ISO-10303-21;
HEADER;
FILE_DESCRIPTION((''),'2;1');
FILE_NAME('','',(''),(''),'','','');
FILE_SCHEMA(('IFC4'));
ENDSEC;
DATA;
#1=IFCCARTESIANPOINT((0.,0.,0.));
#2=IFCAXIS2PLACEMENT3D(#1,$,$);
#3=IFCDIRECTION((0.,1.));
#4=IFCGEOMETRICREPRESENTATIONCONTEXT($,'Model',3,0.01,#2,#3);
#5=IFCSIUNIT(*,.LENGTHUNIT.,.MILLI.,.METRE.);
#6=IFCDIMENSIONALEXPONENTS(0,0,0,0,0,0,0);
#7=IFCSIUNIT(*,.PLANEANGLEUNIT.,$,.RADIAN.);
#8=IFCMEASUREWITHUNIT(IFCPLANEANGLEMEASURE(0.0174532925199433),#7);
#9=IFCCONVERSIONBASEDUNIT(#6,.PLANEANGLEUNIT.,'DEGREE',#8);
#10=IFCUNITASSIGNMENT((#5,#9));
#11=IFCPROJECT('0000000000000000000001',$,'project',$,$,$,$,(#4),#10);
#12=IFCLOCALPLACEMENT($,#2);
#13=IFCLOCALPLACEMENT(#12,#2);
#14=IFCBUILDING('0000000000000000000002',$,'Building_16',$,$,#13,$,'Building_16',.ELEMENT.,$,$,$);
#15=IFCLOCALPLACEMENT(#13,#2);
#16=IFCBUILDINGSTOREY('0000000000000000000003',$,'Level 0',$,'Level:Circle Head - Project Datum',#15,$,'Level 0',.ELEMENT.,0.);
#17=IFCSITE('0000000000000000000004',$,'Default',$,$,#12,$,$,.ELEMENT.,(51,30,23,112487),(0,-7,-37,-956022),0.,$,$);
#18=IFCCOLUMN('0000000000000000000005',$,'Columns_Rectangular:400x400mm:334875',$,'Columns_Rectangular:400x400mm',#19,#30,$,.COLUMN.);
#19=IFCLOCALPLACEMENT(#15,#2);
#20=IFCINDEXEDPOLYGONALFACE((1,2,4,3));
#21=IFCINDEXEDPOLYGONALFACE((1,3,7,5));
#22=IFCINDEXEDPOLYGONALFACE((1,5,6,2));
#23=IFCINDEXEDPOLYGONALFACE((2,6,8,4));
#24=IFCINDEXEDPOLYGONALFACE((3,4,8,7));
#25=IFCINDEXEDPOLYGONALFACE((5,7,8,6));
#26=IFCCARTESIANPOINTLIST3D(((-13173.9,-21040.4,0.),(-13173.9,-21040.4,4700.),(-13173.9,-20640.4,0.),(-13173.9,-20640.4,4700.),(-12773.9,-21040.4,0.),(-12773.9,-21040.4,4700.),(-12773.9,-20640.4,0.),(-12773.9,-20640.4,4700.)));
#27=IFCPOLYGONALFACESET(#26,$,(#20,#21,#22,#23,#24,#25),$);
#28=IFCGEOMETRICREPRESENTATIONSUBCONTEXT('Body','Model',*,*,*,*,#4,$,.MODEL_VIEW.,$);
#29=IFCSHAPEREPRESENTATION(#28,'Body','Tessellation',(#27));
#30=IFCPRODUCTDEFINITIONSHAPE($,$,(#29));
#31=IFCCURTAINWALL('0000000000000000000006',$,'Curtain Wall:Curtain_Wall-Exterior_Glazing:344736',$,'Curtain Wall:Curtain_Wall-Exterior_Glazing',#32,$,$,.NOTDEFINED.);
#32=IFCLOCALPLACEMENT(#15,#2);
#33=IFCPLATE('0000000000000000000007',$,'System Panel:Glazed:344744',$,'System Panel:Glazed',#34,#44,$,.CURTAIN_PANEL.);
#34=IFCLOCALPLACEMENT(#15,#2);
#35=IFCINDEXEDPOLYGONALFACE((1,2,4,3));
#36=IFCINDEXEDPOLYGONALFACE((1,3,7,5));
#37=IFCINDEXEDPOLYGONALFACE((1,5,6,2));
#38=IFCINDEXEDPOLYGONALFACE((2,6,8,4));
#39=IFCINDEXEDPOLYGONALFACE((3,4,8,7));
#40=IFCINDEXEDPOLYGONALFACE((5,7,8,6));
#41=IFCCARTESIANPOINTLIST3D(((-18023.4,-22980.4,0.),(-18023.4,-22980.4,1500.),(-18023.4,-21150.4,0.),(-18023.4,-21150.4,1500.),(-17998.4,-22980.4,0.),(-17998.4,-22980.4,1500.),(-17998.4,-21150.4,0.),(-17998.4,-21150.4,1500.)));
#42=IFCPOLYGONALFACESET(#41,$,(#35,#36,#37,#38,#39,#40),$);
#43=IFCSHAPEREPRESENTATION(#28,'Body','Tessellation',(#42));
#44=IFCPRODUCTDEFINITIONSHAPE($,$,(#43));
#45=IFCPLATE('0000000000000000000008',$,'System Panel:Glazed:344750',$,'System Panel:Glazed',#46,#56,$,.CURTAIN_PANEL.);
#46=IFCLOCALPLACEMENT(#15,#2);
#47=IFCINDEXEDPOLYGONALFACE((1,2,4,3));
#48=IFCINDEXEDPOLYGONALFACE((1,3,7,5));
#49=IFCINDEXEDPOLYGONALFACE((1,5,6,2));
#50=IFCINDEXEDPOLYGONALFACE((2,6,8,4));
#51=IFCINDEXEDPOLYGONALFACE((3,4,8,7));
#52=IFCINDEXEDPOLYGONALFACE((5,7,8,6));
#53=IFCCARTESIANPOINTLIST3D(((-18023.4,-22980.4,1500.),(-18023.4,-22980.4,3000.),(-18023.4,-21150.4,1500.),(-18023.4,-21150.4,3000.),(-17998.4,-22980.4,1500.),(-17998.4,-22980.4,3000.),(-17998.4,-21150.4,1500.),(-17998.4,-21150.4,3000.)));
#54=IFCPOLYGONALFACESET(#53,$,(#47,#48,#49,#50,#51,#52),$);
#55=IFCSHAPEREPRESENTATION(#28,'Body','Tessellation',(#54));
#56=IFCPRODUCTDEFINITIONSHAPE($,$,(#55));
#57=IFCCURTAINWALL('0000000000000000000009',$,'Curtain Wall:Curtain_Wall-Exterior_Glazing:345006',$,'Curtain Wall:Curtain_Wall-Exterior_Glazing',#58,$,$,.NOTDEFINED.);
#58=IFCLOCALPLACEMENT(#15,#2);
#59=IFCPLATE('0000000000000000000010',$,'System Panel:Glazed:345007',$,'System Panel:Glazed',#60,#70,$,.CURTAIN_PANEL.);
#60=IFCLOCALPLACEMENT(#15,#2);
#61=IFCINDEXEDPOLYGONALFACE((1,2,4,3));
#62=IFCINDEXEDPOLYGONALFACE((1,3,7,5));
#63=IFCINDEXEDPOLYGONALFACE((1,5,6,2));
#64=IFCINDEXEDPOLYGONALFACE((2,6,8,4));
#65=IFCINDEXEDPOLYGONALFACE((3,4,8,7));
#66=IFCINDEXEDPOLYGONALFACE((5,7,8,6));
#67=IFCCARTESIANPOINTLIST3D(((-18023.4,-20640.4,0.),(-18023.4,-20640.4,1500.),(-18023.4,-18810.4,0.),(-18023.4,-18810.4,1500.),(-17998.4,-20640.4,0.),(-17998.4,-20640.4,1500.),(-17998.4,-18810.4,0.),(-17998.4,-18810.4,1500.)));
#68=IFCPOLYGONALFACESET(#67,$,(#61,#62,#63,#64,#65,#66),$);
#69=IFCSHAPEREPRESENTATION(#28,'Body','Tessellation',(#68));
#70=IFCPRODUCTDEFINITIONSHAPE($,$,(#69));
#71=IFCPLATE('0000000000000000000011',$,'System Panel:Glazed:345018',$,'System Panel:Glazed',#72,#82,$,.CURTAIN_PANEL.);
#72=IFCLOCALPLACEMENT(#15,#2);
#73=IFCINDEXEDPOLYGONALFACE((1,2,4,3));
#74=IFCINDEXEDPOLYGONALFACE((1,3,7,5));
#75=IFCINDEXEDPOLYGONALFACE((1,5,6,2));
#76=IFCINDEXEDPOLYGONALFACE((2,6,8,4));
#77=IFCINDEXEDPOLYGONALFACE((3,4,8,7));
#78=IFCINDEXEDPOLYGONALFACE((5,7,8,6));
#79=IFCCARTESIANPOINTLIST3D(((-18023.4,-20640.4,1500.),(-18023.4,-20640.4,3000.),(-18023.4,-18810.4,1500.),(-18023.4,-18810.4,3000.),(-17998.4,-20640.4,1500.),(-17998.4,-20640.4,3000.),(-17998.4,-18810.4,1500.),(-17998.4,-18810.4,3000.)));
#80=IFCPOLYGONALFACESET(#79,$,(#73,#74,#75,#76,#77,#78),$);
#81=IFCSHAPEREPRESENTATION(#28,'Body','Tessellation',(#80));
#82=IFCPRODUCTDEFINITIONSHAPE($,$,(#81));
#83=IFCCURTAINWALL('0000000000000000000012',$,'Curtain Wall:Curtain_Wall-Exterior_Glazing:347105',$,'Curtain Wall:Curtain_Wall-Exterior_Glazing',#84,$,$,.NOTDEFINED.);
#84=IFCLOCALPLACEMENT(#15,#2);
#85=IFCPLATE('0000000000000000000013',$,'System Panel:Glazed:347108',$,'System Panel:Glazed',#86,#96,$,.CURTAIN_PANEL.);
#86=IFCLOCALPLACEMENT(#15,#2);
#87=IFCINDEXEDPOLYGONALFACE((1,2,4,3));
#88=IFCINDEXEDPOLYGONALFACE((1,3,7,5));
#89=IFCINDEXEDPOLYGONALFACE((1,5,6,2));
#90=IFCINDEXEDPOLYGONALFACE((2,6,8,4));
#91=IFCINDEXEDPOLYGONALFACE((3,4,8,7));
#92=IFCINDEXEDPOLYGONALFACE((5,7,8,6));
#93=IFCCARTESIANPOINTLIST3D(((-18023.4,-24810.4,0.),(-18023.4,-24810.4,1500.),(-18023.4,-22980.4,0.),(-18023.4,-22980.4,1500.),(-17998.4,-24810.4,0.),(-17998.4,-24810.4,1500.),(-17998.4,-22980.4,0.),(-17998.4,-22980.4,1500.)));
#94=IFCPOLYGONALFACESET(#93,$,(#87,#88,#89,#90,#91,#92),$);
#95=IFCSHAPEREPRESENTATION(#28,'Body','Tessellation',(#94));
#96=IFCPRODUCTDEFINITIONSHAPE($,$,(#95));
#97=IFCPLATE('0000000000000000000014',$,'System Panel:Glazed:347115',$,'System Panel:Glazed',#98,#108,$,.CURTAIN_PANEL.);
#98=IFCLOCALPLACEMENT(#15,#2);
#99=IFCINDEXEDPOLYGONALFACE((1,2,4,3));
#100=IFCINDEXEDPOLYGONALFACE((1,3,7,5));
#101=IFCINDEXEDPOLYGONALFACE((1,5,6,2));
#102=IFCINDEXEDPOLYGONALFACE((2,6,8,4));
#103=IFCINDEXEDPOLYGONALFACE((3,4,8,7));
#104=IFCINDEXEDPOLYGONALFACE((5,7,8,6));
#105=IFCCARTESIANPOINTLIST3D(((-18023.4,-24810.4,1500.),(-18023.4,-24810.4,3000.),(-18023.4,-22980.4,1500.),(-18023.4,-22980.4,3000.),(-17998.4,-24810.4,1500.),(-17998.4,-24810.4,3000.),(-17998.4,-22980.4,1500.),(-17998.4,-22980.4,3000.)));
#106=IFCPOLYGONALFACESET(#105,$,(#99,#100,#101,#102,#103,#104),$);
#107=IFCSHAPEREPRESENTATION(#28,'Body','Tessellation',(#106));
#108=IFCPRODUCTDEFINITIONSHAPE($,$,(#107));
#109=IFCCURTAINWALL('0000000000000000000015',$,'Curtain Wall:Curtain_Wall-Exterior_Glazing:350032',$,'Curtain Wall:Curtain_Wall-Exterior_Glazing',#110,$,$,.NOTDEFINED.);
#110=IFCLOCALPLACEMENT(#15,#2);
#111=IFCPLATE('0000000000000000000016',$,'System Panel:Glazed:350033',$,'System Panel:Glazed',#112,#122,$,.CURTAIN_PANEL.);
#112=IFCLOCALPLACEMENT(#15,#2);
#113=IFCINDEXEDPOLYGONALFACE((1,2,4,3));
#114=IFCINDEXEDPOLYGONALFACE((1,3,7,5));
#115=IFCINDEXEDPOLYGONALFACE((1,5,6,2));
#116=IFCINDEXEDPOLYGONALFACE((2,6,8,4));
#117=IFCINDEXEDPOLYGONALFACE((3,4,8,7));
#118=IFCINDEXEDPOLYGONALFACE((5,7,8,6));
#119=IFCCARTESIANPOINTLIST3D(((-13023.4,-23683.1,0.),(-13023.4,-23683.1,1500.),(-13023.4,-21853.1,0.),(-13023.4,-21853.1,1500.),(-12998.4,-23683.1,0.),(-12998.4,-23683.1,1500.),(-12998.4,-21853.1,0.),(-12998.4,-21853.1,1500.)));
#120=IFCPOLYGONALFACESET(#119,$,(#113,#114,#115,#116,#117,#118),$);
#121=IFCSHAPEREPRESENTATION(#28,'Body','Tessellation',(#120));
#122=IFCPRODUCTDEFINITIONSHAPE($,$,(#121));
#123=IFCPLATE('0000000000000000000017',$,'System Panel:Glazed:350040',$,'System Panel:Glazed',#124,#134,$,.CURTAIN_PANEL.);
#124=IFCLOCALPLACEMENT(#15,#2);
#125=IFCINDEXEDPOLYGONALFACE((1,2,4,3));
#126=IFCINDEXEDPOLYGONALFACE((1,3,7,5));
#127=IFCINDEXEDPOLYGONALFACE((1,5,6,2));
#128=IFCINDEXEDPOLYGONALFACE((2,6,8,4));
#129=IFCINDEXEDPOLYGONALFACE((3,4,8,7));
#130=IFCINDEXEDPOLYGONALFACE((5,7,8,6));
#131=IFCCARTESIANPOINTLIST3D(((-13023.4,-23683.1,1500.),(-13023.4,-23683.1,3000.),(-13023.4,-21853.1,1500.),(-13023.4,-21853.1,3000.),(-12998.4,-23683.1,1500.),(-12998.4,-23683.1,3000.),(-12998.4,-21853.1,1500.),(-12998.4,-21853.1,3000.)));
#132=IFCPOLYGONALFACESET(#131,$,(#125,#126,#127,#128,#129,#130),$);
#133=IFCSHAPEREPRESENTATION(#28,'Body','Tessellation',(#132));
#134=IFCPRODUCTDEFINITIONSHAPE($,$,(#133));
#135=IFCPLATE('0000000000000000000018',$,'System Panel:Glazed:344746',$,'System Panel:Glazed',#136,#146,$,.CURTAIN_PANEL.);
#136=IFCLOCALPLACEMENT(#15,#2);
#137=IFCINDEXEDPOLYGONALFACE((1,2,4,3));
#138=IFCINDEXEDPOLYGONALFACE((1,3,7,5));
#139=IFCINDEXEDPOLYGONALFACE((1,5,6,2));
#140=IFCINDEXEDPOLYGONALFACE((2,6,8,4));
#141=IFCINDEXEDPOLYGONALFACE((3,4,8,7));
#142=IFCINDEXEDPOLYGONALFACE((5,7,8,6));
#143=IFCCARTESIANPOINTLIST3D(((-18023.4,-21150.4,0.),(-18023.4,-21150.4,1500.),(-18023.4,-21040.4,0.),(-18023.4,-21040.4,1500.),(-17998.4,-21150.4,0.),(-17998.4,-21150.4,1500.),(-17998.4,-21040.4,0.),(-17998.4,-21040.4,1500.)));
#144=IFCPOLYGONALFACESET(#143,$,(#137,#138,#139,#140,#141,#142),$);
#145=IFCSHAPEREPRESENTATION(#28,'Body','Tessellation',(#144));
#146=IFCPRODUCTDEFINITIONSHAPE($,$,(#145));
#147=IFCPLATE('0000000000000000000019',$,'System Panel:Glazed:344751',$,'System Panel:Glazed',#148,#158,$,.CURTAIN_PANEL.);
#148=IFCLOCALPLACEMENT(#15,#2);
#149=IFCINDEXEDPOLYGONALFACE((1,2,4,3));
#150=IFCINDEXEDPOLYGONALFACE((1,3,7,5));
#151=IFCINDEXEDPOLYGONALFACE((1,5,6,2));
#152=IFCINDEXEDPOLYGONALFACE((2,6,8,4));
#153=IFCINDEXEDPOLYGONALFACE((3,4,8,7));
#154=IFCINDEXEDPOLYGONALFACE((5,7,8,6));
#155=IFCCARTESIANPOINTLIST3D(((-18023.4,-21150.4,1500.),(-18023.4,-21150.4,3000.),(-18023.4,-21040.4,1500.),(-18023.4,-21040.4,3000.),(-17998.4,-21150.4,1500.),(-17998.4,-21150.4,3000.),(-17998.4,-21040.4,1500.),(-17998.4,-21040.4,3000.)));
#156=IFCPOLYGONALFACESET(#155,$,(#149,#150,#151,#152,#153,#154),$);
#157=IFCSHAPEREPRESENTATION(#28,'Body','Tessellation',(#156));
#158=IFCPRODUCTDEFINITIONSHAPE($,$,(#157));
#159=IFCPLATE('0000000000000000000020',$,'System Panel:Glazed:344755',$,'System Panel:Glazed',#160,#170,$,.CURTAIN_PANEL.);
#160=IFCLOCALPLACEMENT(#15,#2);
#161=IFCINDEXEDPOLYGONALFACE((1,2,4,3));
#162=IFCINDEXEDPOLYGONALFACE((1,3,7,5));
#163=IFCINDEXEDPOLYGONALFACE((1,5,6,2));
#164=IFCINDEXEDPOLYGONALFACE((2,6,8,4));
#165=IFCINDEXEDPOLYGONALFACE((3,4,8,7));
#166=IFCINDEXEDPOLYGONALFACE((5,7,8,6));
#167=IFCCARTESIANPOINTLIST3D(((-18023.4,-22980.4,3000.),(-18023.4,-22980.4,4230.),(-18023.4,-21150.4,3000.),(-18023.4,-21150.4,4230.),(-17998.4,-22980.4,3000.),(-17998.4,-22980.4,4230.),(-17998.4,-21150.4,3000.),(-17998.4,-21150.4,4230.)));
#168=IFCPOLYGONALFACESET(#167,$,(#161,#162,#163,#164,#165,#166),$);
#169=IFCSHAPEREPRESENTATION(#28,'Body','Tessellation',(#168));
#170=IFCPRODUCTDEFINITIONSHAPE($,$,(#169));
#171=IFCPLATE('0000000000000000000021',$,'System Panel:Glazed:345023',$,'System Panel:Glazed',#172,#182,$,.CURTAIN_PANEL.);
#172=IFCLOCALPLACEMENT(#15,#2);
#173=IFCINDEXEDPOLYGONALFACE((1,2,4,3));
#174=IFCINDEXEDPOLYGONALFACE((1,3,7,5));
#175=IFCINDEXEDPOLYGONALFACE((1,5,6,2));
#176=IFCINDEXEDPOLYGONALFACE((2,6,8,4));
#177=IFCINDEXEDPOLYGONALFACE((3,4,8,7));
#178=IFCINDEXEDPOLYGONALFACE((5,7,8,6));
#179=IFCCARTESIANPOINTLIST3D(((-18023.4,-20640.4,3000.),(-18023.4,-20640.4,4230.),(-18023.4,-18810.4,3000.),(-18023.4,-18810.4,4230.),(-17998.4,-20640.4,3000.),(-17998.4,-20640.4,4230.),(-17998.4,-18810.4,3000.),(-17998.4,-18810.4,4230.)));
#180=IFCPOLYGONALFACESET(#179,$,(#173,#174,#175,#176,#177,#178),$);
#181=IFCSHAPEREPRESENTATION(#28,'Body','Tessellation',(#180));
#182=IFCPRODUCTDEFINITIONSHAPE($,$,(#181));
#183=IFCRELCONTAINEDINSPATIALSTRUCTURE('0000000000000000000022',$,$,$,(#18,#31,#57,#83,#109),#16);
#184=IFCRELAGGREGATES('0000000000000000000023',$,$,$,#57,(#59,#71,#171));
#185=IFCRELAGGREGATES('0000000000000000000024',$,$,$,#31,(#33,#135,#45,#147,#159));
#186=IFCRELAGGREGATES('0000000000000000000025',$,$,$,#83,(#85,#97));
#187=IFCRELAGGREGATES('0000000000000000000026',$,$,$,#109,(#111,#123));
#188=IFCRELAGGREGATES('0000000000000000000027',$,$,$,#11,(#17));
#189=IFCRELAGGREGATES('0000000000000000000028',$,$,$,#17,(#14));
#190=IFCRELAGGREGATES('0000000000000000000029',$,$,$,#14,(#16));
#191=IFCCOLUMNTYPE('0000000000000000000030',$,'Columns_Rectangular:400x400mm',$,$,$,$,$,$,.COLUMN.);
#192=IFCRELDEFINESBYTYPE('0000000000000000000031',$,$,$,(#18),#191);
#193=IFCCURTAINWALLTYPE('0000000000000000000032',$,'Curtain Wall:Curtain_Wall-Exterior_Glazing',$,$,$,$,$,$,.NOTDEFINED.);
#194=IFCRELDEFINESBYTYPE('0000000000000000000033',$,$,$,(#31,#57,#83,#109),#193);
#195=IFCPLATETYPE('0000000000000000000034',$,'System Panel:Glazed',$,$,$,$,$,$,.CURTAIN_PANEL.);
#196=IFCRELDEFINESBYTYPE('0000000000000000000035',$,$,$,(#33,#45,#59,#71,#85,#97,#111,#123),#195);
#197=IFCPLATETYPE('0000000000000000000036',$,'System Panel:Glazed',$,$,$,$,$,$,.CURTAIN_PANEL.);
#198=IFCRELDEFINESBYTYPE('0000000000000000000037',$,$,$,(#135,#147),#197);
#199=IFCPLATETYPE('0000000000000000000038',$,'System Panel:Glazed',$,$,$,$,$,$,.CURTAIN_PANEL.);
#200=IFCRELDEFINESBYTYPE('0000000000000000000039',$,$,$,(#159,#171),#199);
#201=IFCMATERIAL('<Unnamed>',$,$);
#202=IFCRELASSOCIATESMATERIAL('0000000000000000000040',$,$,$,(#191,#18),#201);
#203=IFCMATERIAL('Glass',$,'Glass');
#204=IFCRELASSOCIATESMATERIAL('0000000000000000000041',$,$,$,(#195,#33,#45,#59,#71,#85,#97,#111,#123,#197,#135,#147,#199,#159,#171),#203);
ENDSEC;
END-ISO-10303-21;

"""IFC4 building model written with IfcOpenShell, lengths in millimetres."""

from ifc_helpers import new_model, entity, si_unit, converted_unit, direction, frame, origin, place, context, subcontext, project, spatial, indexed_curve, outline, extrude, source, transform, mapped, material, type_object, type_shapes, element, aggregate, save


model = new_model("IFC4")

# Units and contexts
model_context = context("Model", 3, precision=0.01, world=origin(), true_north=direction((0.0, 1.0)))
body_context = subcontext(model_context, "Body", "Model", "MODEL_VIEW")
ifc_project = project(units=[si_unit("LENGTHUNIT", "METRE", prefix="MILLI"), converted_unit("PLANEANGLEUNIT", "DEGREE", entity("IfcPlaneAngleMeasure", 0.0174532925199433), si_unit("PLANEANGLEUNIT", "RADIAN"), dimensions=[0, 0, 0, 0, 0, 0, 0])], contexts=[model_context])

# Site, building, storey
site_placement = place(None, origin())
site = spatial("IfcSite", under=ifc_project, at=site_placement, Name="Default", CompositionType="ELEMENT", RefLatitude=(51, 30, 23, 112487), RefLongitude=(0, -7, -37, -956022), RefElevation=0.0)
building_placement = place(site_placement, origin())
building = spatial("IfcBuilding", under=site, at=building_placement, Name="Building_16", LongName="Building_16", CompositionType="ELEMENT")
storey_placement = place(building_placement, origin())
storey = spatial("IfcBuildingStorey", under=building, at=storey_placement, Name="Level 0", ObjectType="Level:Circle Head - Project Datum", LongName="Level 0", CompositionType="ELEMENT", Elevation=0.0)

# Column
ifc_material_1 = material(Name="<Unnamed>")
column_type = type_object("IfcColumnType", Name="Columns_Rectangular:400x400mm", PredefinedType="COLUMN", material=ifc_material_1)
shared_shape_1 = source(origin(), body_context, "Body", "SweptSolid", [
    extrude(outline(indexed_curve([(-200.0, -200.0), (200.0, -200.0), (200.0, 200.0), (-200.0, 200.0), (-200.0, -200.0)], self_intersect=False)), frame((0.0, 0.0, 0.0), z_axis=(0.0, 0.0, 1.0), x_axis=(-1.0, 0.0, 0.0)), (0.0, 0.0, 1.0), 4700.0),
])
type_shapes(column_type, [shared_shape_1])
column_placement = place(storey_placement, frame((-12973.9, -20840.4, 0.0)))
element("IfcColumn", 1, at=column_placement, inside=storey, type_object=column_type, material=ifc_material_1, Name="Columns_Rectangular:400x400mm:334875", ObjectType="Columns_Rectangular:400x400mm", PredefinedType="COLUMN", context=body_context, shape_type="MappedRepresentation", body=[
    mapped(shared_shape_1, transform((0.0, 0.0, 0.0), scale=1.0)),
])

# Curtain walls, plates
curtain_wall_type = type_object("IfcCurtainWallType", Name="Curtain Wall:Curtain_Wall-Exterior_Glazing", PredefinedType="NOTDEFINED")
curtain_wall_1_placement = place(storey_placement, origin())
curtain_wall_1 = element("IfcCurtainWall", 2, at=curtain_wall_1_placement, inside=storey, type_object=curtain_wall_type, Name="Curtain Wall:Curtain_Wall-Exterior_Glazing:344736", ObjectType="Curtain Wall:Curtain_Wall-Exterior_Glazing", PredefinedType="NOTDEFINED")
ifc_material_2 = material(Name="Glass", Category="Glass")
plate_type_1 = type_object("IfcPlateType", Name="System Panel:Glazed", PredefinedType="CURTAIN_PANEL", material=ifc_material_2)
shared_shape_2 = source(origin(), body_context, "Body", "SweptSolid", [
    extrude(outline(indexed_curve([(-12.5, -915.0), (12.5, -915.0), (12.5, 915.0), (-12.5, 915.0), (-12.5, -915.0)], self_intersect=False)), frame((0.0, 37.0, 0.0), z_axis=(0.0, 0.0, 1.0), x_axis=(0.0, 1.0, 0.0)), (0.0, 0.0, 1.0), 1500.0),
])
type_shapes(plate_type_1, [shared_shape_2])
plate_1_placement = place(curtain_wall_1_placement, frame((-17973.9, -22065.4, 0.0), z_axis=(0.0, 0.0, 1.0), x_axis=(0.0, 1.0, 0.0)))
plate_1 = element("IfcPlate", 3, at=plate_1_placement, type_object=plate_type_1, material=ifc_material_2, Name="System Panel:Glazed:344744", ObjectType="System Panel:Glazed", PredefinedType="CURTAIN_PANEL", context=body_context, shape_type="MappedRepresentation", body=[
    mapped(shared_shape_2, transform((0.0, 0.0, 0.0), scale=1.0)),
])
plate_2_placement = place(curtain_wall_1_placement, frame((-17973.9, -22065.4, 1500.0), z_axis=(0.0, 0.0, 1.0), x_axis=(0.0, 1.0, 0.0)))
plate_2 = element("IfcPlate", 4, at=plate_2_placement, type_object=plate_type_1, material=ifc_material_2, Name="System Panel:Glazed:344750", ObjectType="System Panel:Glazed", PredefinedType="CURTAIN_PANEL", context=body_context, shape_type="MappedRepresentation", body=[
    mapped(shared_shape_2, transform((0.0, 0.0, 0.0), scale=1.0)),
])
curtain_wall_2_placement = place(storey_placement, origin())
curtain_wall_2 = element("IfcCurtainWall", 5, at=curtain_wall_2_placement, inside=storey, type_object=curtain_wall_type, Name="Curtain Wall:Curtain_Wall-Exterior_Glazing:345006", ObjectType="Curtain Wall:Curtain_Wall-Exterior_Glazing", PredefinedType="NOTDEFINED")
plate_3_placement = place(curtain_wall_2_placement, frame((-17973.9, -19725.4, 0.0), z_axis=(0.0, 0.0, 1.0), x_axis=(0.0, 1.0, 0.0)))
plate_3 = element("IfcPlate", 6, at=plate_3_placement, type_object=plate_type_1, material=ifc_material_2, Name="System Panel:Glazed:345007", ObjectType="System Panel:Glazed", PredefinedType="CURTAIN_PANEL", context=body_context, shape_type="MappedRepresentation", body=[
    mapped(shared_shape_2, transform((0.0, 0.0, 0.0), scale=1.0)),
])
plate_4_placement = place(curtain_wall_2_placement, frame((-17973.9, -19725.4, 1500.0), z_axis=(0.0, 0.0, 1.0), x_axis=(0.0, 1.0, 0.0)))
plate_4 = element("IfcPlate", 7, at=plate_4_placement, type_object=plate_type_1, material=ifc_material_2, Name="System Panel:Glazed:345018", ObjectType="System Panel:Glazed", PredefinedType="CURTAIN_PANEL", context=body_context, shape_type="MappedRepresentation", body=[
    mapped(shared_shape_2, transform((0.0, 0.0, 0.0), scale=1.0)),
])
curtain_wall_3_placement = place(storey_placement, origin())
curtain_wall_3 = element("IfcCurtainWall", 8, at=curtain_wall_3_placement, inside=storey, type_object=curtain_wall_type, Name="Curtain Wall:Curtain_Wall-Exterior_Glazing:347105", ObjectType="Curtain Wall:Curtain_Wall-Exterior_Glazing", PredefinedType="NOTDEFINED")
plate_5_placement = place(curtain_wall_3_placement, frame((-17973.9, -23895.4, 0.0), z_axis=(0.0, 0.0, 1.0), x_axis=(0.0, 1.0, 0.0)))
plate_5 = element("IfcPlate", 9, at=plate_5_placement, type_object=plate_type_1, material=ifc_material_2, Name="System Panel:Glazed:347108", ObjectType="System Panel:Glazed", PredefinedType="CURTAIN_PANEL", context=body_context, shape_type="MappedRepresentation", body=[
    mapped(shared_shape_2, transform((0.0, 0.0, 0.0), scale=1.0)),
])
plate_6_placement = place(curtain_wall_3_placement, frame((-17973.9, -23895.4, 1500.0), z_axis=(0.0, 0.0, 1.0), x_axis=(0.0, 1.0, 0.0)))
plate_6 = element("IfcPlate", 10, at=plate_6_placement, type_object=plate_type_1, material=ifc_material_2, Name="System Panel:Glazed:347115", ObjectType="System Panel:Glazed", PredefinedType="CURTAIN_PANEL", context=body_context, shape_type="MappedRepresentation", body=[
    mapped(shared_shape_2, transform((0.0, 0.0, 0.0), scale=1.0)),
])

# Curtain wall, plates
curtain_wall_4_placement = place(storey_placement, origin())
curtain_wall_4 = element("IfcCurtainWall", 11, at=curtain_wall_4_placement, inside=storey, type_object=curtain_wall_type, Name="Curtain Wall:Curtain_Wall-Exterior_Glazing:350032", ObjectType="Curtain Wall:Curtain_Wall-Exterior_Glazing", PredefinedType="NOTDEFINED")
plate_7_placement = place(curtain_wall_4_placement, frame((-12973.9, -22768.1, 0.0), z_axis=(0.0, 0.0, 1.0), x_axis=(0.0, 1.0, 0.0)))
plate_7 = element("IfcPlate", 12, at=plate_7_placement, type_object=plate_type_1, material=ifc_material_2, Name="System Panel:Glazed:350033", ObjectType="System Panel:Glazed", PredefinedType="CURTAIN_PANEL", context=body_context, shape_type="MappedRepresentation", body=[
    mapped(shared_shape_2, transform((0.0, 0.0, 0.0), scale=1.0)),
])
plate_8_placement = place(curtain_wall_4_placement, frame((-12973.9, -22768.1, 1500.0), z_axis=(0.0, 0.0, 1.0), x_axis=(0.0, 1.0, 0.0)))
plate_8 = element("IfcPlate", 13, at=plate_8_placement, type_object=plate_type_1, material=ifc_material_2, Name="System Panel:Glazed:350040", ObjectType="System Panel:Glazed", PredefinedType="CURTAIN_PANEL", context=body_context, shape_type="MappedRepresentation", body=[
    mapped(shared_shape_2, transform((0.0, 0.0, 0.0), scale=1.0)),
])

# Plates
plate_type_2 = type_object("IfcPlateType", Name="System Panel:Glazed", PredefinedType="CURTAIN_PANEL", material=ifc_material_2)
shared_shape_3 = source(origin(), body_context, "Body", "SweptSolid", [
    extrude(outline(indexed_curve([(-12.5, -55.0), (12.5, -55.0), (12.5, 55.0), (-12.5, 55.0), (-12.5, -55.0)], self_intersect=False)), frame((0.0, 37.0, 0.0), z_axis=(0.0, 0.0, 1.0), x_axis=(0.0, 1.0, 0.0)), (0.0, 0.0, 1.0), 1500.0),
])
type_shapes(plate_type_2, [shared_shape_3])
plate_9_placement = place(curtain_wall_1_placement, frame((-17973.9, -21095.4, 0.0), z_axis=(0.0, 0.0, 1.0), x_axis=(0.0, 1.0, 0.0)))
plate_9 = element("IfcPlate", 14, at=plate_9_placement, type_object=plate_type_2, material=ifc_material_2, Name="System Panel:Glazed:344746", ObjectType="System Panel:Glazed", PredefinedType="CURTAIN_PANEL", context=body_context, shape_type="MappedRepresentation", body=[
    mapped(shared_shape_3, transform((0.0, 0.0, 0.0), scale=1.0)),
])
plate_10_placement = place(curtain_wall_1_placement, frame((-17973.9, -21095.4, 1500.0), z_axis=(0.0, 0.0, 1.0), x_axis=(0.0, 1.0, 0.0)))
plate_10 = element("IfcPlate", 15, at=plate_10_placement, type_object=plate_type_2, material=ifc_material_2, Name="System Panel:Glazed:344751", ObjectType="System Panel:Glazed", PredefinedType="CURTAIN_PANEL", context=body_context, shape_type="MappedRepresentation", body=[
    mapped(shared_shape_3, transform((0.0, 0.0, 0.0), scale=1.0)),
])
plate_type_3 = type_object("IfcPlateType", Name="System Panel:Glazed", PredefinedType="CURTAIN_PANEL", material=ifc_material_2)
shared_shape_4 = source(origin(), body_context, "Body", "SweptSolid", [
    extrude(outline(indexed_curve([(-12.5, -915.0), (12.5, -915.0), (12.5, 915.0), (-12.5, 915.0), (-12.5, -915.0)], self_intersect=False)), frame((0.0, 37.0, 0.0), z_axis=(0.0, 0.0, 1.0), x_axis=(0.0, 1.0, 0.0)), (0.0, 0.0, 1.0), 1230.0),
])
type_shapes(plate_type_3, [shared_shape_4])
plate_11_placement = place(curtain_wall_1_placement, frame((-17973.9, -22065.4, 3000.0), z_axis=(0.0, 0.0, 1.0), x_axis=(0.0, 1.0, 0.0)))
plate_11 = element("IfcPlate", 16, at=plate_11_placement, type_object=plate_type_3, material=ifc_material_2, Name="System Panel:Glazed:344755", ObjectType="System Panel:Glazed", PredefinedType="CURTAIN_PANEL", context=body_context, shape_type="MappedRepresentation", body=[
    mapped(shared_shape_4, transform((0.0, 0.0, 0.0), scale=1.0)),
])
plate_12_placement = place(curtain_wall_2_placement, frame((-17973.9, -19725.4, 3000.0), z_axis=(0.0, 0.0, 1.0), x_axis=(0.0, 1.0, 0.0)))
plate_12 = element("IfcPlate", 17, at=plate_12_placement, type_object=plate_type_3, material=ifc_material_2, Name="System Panel:Glazed:345023", ObjectType="System Panel:Glazed", PredefinedType="CURTAIN_PANEL", context=body_context, shape_type="MappedRepresentation", body=[
    mapped(shared_shape_4, transform((0.0, 0.0, 0.0), scale=1.0)),
])
aggregate(curtain_wall_2, [plate_3, plate_4, plate_12])
aggregate(curtain_wall_1, [plate_1, plate_9, plate_2, plate_10, plate_11])
aggregate(curtain_wall_3, [plate_5, plate_6])
aggregate(curtain_wall_4, [plate_7, plate_8])

save(model, "model.ifc")
